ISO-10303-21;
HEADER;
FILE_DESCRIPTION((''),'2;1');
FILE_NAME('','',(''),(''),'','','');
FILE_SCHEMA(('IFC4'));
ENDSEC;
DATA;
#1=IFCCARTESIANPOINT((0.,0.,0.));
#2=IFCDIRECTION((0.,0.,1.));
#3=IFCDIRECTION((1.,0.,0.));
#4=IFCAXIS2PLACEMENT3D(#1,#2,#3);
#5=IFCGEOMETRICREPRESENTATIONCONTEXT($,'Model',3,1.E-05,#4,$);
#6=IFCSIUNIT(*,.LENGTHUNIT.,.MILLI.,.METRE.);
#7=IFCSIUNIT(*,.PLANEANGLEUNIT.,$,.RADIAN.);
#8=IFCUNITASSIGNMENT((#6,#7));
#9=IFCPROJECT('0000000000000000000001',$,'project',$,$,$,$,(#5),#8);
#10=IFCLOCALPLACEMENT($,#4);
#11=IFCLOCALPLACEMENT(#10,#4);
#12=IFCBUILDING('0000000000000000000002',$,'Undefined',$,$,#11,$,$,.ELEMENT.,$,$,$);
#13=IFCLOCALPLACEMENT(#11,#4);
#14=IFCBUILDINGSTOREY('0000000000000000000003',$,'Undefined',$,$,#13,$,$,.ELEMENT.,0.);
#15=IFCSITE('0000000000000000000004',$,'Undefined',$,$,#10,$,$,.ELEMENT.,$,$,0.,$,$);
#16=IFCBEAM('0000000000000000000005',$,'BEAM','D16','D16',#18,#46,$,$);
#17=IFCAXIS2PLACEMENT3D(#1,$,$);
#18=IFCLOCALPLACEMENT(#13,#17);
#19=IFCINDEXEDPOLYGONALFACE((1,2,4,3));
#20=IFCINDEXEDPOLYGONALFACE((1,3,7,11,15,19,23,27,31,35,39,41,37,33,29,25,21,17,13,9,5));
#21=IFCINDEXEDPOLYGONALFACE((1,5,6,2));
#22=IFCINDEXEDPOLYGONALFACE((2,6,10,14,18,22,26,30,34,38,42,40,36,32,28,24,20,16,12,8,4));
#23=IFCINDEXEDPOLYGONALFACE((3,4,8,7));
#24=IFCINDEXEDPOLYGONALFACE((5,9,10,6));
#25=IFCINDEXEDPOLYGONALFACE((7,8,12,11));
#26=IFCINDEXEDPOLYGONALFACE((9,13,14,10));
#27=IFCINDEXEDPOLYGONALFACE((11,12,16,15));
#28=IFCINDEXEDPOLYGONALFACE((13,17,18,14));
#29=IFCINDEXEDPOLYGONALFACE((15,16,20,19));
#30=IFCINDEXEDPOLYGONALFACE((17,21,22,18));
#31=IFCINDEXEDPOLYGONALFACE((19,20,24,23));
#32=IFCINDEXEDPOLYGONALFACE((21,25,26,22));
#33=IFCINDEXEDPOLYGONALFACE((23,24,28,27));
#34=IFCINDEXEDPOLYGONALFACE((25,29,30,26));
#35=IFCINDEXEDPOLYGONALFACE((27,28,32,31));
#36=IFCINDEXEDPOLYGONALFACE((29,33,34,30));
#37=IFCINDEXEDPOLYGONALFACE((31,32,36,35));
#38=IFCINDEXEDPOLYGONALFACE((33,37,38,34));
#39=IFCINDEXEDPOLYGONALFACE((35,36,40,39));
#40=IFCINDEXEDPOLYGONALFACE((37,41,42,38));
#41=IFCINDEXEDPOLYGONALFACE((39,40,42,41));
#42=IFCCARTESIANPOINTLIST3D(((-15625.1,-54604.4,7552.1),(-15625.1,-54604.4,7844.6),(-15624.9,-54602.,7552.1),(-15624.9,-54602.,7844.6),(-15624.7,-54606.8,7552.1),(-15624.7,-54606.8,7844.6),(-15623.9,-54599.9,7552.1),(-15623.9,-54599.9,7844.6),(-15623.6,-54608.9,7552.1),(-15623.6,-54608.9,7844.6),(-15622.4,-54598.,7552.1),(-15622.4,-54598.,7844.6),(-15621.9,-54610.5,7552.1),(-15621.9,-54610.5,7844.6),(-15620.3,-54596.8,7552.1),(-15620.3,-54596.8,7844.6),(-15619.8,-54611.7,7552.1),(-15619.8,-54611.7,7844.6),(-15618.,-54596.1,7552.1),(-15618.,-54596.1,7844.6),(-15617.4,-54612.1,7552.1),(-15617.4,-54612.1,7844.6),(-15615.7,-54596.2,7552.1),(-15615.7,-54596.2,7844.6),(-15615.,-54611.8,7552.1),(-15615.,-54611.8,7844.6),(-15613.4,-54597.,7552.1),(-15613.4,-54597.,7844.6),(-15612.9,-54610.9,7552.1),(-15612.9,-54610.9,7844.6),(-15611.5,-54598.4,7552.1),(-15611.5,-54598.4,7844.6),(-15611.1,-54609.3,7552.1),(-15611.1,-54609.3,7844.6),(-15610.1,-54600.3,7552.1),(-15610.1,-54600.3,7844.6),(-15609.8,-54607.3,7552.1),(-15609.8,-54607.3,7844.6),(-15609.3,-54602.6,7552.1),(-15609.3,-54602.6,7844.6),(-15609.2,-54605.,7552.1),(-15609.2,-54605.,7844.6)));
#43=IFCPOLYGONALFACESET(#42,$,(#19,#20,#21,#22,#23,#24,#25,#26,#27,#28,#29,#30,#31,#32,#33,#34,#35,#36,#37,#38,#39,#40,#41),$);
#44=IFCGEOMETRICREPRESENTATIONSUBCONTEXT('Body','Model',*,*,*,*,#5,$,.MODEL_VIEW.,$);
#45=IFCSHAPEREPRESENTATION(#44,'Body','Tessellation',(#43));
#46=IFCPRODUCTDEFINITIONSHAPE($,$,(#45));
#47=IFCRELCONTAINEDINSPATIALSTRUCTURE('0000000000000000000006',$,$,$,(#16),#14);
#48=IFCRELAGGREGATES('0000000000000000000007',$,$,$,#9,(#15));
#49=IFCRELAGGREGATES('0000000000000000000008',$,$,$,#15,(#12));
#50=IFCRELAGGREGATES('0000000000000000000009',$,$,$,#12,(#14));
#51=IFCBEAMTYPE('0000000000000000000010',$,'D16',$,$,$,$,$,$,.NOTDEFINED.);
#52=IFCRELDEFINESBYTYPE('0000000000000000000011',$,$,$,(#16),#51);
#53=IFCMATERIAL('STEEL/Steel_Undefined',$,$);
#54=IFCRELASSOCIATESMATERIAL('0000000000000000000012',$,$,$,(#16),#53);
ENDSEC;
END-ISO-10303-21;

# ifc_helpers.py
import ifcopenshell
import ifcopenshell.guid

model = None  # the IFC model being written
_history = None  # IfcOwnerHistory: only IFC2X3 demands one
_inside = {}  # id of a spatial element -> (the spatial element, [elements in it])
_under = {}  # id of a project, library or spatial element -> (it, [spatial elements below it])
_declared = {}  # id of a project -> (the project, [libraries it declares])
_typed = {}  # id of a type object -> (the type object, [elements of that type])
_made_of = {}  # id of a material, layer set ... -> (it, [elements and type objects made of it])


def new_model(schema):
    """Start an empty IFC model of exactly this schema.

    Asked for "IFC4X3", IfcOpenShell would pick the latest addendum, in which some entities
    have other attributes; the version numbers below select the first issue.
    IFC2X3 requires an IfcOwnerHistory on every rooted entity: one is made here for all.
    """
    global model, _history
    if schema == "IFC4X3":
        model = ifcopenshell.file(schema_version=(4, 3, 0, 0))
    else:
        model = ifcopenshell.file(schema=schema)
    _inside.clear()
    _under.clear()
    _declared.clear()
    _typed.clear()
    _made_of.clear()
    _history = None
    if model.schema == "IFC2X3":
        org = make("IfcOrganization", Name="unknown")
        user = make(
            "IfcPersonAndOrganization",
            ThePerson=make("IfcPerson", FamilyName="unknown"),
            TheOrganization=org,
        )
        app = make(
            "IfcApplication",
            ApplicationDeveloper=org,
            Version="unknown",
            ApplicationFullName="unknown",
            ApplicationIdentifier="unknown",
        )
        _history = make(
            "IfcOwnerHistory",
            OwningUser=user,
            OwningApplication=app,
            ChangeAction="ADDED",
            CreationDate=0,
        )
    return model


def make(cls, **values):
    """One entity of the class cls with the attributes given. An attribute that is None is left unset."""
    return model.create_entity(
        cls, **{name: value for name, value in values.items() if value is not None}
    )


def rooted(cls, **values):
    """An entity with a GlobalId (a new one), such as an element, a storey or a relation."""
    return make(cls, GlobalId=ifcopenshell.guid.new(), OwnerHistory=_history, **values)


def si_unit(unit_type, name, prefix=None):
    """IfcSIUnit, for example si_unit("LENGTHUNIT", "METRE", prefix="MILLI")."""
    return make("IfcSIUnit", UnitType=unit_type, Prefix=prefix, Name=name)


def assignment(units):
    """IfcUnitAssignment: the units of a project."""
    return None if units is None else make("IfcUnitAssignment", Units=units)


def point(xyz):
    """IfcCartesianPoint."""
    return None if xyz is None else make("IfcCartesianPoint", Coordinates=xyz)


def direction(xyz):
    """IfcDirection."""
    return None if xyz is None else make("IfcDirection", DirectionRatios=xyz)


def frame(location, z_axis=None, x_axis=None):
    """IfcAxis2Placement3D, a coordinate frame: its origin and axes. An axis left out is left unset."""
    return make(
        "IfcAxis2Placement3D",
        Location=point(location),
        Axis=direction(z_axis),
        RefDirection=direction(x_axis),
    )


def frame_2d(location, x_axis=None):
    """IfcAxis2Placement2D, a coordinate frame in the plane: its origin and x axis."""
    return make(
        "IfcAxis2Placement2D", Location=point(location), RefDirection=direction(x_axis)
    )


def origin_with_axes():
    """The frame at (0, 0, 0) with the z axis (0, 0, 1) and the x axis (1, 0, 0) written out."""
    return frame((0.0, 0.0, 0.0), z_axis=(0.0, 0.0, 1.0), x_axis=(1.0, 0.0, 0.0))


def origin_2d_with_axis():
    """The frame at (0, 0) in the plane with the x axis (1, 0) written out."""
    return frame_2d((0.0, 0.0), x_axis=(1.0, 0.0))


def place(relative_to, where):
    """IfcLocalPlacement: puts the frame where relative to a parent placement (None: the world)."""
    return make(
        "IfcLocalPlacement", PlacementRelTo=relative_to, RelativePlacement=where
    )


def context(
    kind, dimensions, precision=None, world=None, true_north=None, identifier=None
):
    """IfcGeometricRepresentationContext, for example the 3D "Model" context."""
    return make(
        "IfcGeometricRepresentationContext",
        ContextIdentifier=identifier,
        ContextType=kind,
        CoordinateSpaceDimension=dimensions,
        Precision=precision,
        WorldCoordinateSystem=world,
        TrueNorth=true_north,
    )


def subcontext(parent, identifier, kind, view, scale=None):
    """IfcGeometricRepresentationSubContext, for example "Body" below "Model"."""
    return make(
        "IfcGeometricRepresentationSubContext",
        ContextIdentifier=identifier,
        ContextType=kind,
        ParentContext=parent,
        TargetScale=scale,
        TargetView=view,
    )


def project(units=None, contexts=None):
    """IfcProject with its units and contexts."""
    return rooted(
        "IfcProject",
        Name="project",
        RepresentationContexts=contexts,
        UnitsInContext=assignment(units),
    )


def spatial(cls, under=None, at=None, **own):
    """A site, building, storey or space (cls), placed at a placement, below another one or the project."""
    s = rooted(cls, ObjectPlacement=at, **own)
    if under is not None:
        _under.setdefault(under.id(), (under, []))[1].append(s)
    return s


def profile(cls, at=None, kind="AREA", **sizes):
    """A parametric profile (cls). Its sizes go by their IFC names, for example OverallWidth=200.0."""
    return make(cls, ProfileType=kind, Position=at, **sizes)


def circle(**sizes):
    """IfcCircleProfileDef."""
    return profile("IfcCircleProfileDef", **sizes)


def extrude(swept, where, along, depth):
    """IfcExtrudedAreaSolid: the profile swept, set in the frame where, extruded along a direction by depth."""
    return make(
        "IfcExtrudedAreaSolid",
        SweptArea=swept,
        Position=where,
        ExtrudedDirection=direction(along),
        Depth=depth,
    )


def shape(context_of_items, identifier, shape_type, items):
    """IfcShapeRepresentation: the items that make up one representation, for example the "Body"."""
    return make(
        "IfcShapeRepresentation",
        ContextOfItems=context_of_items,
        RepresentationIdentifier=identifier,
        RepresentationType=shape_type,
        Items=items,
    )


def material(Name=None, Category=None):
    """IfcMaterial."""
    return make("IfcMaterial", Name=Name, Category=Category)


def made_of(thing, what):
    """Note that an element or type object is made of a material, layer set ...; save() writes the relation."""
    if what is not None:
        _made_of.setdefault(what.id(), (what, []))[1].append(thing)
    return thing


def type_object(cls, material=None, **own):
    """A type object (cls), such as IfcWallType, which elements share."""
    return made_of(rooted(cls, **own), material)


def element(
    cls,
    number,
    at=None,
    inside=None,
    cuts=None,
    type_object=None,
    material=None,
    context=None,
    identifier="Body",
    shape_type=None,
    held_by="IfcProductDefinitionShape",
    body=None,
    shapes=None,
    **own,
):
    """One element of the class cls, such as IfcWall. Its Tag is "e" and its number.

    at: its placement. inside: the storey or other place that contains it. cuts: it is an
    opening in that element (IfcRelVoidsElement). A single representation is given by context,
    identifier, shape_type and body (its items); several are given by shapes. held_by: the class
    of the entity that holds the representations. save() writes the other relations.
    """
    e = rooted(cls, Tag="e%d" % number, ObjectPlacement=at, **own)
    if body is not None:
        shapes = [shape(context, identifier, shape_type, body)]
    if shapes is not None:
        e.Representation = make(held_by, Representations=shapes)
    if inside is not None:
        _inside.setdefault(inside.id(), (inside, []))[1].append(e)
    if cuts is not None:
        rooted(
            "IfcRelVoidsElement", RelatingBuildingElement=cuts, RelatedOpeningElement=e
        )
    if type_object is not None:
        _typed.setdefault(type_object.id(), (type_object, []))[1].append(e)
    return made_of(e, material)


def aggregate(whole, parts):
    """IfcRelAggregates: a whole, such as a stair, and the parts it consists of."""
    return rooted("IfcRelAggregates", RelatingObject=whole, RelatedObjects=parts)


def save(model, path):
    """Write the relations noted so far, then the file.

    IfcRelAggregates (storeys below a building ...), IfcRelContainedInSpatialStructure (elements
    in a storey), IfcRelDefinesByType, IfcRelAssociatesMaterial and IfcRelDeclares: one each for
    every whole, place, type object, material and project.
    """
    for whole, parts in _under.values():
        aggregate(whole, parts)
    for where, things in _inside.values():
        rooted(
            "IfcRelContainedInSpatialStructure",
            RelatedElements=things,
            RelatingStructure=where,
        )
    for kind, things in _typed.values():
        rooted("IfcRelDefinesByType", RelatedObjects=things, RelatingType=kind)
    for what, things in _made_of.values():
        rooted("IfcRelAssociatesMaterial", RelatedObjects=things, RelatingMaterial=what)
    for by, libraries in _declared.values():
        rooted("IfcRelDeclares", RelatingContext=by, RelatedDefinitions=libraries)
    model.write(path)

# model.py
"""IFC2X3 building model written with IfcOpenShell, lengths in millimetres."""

from ifc_helpers import new_model, si_unit, frame, origin_with_axes, origin_2d_with_axis, place, context, subcontext, project, spatial, circle, extrude, material, type_object, element, save


model = new_model("IFC2X3")

# Units and contexts
model_context = context("Model", 3, precision=1e-05, world=origin_with_axes())
body_context = subcontext(model_context, "Body", "Model", "MODEL_VIEW")
ifc_project = project(units=[si_unit("LENGTHUNIT", "METRE", prefix="MILLI"), si_unit("PLANEANGLEUNIT", "RADIAN")], contexts=[model_context])

# Site, building, storey
site_placement = place(None, origin_with_axes())
site = spatial("IfcSite", under=ifc_project, at=site_placement, Name="Undefined", CompositionType="ELEMENT", RefElevation=0.0)
building_placement = place(site_placement, origin_with_axes())
building = spatial("IfcBuilding", under=site, at=building_placement, Name="Undefined", CompositionType="ELEMENT")
storey_placement = place(building_placement, origin_with_axes())
storey = spatial("IfcBuildingStorey", under=building, at=storey_placement, Name="Undefined", CompositionType="ELEMENT", Elevation=0.0)

# Shared definitions
ifc_material_1 = material(Name="STEEL/Steel_Undefined")

# Beam
beam_type_1 = type_object("IfcBeamType", Name="D16", PredefinedType="NOTDEFINED")
for number, where, z_axis, x_axis, name in (
    (1, (-15617.1, -54604.1, 7844.6), (-0.915553, -0.402197, 0.0), (0.0, 0.0, -1.0), "BEAM"),
):
    element("IfcBeam", number, at=place(storey_placement, frame(where, z_axis=z_axis, x_axis=x_axis)), inside=storey, type_object=beam_type_1, material=ifc_material_1, Name=name, Description="D16", ObjectType="D16", context=body_context, shape_type="SweptSolid", body=[
        extrude(circle(Radius=8.0, at=origin_2d_with_axis()), frame((292.6, 0.0, 0.0), z_axis=(-1.0, 0.0, 0.0), x_axis=(0.0, -1.0, 0.0)), (0.0, 0.0, 1.0), 292.6),
    ])

save(model, "model.ifc")
